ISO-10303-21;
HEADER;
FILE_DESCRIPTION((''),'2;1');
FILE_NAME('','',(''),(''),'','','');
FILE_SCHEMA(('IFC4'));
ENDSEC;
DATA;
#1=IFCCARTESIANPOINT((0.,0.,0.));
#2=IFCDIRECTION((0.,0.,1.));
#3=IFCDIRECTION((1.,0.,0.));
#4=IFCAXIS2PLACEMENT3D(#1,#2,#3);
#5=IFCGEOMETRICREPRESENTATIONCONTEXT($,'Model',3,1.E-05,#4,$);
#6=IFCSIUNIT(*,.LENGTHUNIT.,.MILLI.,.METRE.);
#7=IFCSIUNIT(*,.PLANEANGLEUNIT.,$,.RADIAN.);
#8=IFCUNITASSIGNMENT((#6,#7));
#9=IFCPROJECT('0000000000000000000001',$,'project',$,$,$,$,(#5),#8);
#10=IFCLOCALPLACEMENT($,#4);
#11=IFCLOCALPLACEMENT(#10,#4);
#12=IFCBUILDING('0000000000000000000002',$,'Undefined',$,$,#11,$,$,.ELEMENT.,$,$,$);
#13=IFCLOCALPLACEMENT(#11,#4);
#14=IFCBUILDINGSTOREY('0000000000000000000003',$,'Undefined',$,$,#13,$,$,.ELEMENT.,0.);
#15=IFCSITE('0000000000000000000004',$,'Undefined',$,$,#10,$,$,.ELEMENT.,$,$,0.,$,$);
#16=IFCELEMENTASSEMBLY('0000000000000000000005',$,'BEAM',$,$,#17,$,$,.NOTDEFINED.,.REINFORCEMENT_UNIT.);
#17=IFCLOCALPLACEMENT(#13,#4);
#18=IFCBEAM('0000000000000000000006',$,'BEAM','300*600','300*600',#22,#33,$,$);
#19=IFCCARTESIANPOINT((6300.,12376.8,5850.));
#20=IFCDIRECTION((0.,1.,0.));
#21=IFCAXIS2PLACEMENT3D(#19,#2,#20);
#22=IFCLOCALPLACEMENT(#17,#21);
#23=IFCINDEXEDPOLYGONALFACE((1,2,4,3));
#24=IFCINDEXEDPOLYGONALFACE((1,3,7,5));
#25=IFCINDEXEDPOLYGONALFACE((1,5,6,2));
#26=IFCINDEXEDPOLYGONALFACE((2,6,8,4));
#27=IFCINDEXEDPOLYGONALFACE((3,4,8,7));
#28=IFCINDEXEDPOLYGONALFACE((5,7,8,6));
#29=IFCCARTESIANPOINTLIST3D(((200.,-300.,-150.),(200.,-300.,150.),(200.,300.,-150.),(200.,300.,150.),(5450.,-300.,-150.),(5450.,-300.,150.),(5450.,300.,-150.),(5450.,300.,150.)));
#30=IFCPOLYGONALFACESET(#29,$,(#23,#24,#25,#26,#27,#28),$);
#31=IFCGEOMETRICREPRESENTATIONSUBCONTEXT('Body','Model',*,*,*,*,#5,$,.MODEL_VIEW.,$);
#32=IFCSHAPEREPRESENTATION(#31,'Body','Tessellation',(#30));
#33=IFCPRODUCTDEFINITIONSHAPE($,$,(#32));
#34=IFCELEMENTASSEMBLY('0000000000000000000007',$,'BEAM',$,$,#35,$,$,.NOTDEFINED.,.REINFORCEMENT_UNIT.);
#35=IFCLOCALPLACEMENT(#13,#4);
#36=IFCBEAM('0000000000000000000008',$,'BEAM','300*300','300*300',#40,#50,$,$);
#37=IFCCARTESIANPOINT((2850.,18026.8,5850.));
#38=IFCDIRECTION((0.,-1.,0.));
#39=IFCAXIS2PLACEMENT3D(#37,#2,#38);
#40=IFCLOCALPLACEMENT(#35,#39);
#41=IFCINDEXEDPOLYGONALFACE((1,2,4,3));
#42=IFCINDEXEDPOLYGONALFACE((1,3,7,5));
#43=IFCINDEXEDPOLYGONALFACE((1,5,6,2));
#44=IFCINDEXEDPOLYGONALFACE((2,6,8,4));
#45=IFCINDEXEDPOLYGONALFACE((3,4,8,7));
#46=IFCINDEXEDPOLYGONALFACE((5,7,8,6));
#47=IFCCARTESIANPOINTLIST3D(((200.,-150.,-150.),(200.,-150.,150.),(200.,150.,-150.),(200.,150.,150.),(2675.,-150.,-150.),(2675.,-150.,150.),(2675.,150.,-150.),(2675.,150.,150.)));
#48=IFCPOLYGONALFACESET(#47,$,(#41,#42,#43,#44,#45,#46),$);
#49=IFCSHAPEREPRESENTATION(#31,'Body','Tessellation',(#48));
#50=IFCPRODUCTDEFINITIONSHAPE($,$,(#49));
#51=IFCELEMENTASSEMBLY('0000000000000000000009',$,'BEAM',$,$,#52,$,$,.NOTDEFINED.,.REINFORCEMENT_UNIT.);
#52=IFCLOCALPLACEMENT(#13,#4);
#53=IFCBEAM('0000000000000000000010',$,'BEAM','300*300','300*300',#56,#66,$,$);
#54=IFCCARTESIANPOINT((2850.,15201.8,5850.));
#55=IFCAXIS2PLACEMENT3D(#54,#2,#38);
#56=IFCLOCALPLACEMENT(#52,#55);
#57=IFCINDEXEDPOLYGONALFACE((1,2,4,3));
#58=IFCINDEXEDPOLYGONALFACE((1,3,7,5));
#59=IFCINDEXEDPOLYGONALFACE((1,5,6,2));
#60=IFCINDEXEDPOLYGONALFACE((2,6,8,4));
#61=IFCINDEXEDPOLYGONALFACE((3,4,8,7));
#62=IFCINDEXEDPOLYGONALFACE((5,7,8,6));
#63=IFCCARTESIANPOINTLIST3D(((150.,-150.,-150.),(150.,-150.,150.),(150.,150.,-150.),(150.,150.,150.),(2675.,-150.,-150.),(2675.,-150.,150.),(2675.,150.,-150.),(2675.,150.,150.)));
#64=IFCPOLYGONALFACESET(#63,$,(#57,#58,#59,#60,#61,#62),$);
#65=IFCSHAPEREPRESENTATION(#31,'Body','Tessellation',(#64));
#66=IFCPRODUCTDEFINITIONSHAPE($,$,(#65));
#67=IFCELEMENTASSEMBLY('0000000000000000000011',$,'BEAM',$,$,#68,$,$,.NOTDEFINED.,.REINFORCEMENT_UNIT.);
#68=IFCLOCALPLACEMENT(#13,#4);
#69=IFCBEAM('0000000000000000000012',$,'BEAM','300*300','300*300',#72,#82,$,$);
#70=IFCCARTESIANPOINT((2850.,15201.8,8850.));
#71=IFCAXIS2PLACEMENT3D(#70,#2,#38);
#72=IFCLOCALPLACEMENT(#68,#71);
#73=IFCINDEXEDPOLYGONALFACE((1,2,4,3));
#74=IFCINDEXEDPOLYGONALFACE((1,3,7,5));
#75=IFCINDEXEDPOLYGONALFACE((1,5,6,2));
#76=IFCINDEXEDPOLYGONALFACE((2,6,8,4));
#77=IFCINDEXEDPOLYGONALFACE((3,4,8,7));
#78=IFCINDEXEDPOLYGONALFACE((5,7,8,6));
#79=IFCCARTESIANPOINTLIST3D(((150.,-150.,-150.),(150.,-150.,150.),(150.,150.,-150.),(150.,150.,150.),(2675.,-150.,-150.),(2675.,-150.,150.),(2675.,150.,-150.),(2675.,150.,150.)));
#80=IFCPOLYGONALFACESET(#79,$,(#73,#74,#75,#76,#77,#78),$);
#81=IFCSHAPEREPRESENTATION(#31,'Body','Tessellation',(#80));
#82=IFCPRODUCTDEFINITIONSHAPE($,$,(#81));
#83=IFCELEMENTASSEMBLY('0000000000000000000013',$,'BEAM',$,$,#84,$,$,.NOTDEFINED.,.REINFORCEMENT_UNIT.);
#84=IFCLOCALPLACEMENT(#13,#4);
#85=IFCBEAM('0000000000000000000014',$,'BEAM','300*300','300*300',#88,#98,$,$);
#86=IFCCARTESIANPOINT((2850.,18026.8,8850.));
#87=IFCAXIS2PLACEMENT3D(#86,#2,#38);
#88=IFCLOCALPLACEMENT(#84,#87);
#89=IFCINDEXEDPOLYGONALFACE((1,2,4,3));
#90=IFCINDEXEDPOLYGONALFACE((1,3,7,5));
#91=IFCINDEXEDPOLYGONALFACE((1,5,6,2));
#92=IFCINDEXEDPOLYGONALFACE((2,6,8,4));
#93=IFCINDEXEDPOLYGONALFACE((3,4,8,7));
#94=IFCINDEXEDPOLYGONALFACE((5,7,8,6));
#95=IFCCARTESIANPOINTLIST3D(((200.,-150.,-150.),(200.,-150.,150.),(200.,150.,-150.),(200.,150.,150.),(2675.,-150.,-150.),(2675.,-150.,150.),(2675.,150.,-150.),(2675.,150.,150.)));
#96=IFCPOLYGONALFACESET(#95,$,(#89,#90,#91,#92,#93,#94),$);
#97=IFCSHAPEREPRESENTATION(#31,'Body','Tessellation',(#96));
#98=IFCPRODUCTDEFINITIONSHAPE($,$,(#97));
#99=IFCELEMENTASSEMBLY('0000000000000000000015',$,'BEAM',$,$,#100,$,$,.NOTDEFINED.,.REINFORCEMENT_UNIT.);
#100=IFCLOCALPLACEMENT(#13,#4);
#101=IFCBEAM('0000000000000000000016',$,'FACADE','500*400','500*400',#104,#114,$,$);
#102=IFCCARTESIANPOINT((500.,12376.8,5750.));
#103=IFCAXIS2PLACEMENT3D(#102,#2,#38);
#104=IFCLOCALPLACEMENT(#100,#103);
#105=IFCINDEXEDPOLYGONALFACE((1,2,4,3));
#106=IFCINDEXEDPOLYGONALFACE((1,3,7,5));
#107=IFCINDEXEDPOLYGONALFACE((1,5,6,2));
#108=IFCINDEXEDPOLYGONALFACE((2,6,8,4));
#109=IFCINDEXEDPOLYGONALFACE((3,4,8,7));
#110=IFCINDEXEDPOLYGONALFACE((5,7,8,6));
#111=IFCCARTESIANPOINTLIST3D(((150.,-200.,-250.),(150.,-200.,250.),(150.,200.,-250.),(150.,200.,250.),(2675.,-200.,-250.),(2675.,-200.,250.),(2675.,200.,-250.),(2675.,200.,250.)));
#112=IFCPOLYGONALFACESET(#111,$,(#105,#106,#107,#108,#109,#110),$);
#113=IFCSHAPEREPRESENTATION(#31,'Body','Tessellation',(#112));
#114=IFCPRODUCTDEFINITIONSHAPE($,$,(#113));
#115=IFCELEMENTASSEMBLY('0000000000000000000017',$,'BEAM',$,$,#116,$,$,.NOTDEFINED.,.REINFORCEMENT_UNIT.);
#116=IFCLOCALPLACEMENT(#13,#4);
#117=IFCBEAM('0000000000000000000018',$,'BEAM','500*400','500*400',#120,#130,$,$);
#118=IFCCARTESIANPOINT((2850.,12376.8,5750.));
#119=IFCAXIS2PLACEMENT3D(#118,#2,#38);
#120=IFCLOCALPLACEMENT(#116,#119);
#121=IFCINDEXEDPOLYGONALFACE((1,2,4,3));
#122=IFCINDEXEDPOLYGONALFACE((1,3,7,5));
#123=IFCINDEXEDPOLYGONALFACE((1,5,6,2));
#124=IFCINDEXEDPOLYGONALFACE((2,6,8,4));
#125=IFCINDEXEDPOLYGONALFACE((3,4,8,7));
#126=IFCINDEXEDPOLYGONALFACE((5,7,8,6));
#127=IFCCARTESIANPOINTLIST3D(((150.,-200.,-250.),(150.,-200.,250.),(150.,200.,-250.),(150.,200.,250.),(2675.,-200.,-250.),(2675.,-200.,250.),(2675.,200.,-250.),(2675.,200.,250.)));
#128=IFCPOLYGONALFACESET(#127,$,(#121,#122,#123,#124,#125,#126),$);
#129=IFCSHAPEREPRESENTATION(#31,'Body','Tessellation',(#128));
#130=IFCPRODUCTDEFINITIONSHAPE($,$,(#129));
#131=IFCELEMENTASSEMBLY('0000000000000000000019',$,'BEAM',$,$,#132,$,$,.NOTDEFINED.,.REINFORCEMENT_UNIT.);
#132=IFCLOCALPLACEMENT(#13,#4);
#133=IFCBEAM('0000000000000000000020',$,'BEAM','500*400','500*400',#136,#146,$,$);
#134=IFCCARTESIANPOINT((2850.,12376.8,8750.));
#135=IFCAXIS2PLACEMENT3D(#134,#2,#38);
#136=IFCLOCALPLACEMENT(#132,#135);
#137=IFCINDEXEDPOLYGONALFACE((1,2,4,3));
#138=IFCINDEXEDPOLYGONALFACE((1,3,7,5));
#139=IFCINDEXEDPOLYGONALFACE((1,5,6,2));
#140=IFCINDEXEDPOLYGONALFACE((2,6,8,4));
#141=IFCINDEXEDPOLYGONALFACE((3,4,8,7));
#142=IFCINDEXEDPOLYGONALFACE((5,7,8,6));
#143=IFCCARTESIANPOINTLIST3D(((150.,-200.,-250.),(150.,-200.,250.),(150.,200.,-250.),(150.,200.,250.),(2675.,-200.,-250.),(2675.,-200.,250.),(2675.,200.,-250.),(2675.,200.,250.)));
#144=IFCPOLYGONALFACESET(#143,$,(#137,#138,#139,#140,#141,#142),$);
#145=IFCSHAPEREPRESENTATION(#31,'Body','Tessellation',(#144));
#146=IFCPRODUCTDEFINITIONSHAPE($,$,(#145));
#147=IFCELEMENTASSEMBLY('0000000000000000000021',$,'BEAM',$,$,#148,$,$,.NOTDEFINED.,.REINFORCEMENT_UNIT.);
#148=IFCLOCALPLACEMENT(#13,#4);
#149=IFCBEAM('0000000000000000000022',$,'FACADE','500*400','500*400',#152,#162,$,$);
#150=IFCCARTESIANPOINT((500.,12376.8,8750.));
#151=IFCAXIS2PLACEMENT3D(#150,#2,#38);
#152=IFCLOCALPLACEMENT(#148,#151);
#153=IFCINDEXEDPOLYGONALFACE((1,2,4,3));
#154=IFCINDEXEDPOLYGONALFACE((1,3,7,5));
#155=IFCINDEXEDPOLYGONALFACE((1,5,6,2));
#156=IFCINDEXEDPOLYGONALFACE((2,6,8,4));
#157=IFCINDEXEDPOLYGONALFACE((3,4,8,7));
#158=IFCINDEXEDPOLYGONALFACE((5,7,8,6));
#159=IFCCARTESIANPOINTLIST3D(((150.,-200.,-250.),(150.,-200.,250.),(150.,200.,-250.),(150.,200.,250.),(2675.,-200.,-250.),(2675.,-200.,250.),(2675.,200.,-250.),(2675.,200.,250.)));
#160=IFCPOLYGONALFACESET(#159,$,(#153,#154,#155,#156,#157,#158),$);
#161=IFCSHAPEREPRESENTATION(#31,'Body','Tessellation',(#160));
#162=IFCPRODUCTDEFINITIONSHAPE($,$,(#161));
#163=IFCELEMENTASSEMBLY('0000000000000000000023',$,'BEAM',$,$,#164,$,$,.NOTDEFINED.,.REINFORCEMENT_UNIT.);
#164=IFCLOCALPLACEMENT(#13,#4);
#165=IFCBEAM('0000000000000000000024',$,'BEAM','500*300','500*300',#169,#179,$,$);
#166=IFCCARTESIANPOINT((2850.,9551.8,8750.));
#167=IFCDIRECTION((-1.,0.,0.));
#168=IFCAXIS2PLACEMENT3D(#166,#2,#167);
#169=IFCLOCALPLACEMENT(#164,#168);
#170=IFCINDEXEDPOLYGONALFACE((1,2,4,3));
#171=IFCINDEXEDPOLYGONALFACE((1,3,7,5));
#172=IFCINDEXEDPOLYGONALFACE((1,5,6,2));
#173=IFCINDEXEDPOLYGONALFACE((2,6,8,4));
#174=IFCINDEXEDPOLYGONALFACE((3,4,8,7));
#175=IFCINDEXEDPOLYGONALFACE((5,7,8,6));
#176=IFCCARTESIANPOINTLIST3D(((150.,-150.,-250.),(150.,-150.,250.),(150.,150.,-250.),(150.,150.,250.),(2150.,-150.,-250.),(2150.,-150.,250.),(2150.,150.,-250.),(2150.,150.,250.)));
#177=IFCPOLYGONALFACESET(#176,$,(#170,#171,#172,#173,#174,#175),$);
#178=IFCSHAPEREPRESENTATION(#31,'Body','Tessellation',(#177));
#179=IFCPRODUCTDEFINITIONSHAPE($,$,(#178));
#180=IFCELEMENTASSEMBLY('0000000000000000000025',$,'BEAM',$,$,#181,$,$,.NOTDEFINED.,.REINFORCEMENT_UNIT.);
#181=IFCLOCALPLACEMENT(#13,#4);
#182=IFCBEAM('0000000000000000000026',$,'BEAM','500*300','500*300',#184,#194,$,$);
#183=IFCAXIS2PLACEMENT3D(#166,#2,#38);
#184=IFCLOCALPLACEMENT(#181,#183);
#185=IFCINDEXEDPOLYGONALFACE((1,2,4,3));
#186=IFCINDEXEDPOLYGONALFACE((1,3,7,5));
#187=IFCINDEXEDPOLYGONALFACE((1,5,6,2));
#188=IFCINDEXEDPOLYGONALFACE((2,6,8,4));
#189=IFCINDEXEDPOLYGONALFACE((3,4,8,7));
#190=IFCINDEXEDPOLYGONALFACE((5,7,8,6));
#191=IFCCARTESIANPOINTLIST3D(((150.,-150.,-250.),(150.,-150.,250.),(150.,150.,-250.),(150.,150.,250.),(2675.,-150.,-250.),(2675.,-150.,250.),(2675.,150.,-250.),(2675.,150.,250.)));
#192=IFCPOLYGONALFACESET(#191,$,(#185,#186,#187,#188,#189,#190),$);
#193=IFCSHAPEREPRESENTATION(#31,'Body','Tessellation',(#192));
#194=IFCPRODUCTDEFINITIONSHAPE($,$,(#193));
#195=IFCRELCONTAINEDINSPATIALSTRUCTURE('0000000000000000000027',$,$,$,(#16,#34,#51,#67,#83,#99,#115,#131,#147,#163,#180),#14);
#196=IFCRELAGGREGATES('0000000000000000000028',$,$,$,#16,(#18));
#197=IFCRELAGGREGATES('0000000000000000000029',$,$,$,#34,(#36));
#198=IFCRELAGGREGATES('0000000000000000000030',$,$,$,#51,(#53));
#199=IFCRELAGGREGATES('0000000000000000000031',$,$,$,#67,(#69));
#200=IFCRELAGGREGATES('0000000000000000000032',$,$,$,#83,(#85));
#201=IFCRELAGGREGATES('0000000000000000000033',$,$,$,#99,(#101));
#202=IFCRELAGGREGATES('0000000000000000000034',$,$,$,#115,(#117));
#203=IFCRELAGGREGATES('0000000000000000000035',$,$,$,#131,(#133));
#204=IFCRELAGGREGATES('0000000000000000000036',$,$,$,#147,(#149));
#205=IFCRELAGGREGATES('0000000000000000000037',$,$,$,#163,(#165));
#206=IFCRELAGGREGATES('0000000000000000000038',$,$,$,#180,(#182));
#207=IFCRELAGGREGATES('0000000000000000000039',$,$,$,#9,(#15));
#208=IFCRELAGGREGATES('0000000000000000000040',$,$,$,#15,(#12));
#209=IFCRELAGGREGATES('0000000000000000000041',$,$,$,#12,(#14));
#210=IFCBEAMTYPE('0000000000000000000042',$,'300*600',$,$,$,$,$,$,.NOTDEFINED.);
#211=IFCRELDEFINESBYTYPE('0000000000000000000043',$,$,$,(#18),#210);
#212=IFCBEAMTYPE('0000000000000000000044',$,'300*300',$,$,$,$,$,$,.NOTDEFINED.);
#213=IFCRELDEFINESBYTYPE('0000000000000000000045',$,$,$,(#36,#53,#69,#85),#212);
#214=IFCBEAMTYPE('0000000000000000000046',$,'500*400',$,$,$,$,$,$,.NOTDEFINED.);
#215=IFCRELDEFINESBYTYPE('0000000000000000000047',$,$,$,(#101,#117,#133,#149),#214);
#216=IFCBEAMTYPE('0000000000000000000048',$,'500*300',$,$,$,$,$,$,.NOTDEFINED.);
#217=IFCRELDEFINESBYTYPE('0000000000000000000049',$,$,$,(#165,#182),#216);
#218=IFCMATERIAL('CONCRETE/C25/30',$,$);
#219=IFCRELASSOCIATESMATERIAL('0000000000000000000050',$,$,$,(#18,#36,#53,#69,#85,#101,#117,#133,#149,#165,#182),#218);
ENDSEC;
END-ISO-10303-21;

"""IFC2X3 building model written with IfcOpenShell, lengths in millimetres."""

from ifc_helpers import new_model, si_unit, frame, origin_with_axes, origin_2d_with_axis, place, context, subcontext, project, spatial, rectangle, extrude, material, type_object, element, aggregate, save


model = new_model("IFC2X3")

# Units and contexts
model_context = context("Model", 3, precision=1e-05, world=origin_with_axes())
body_context = subcontext(model_context, "Body", "Model", "MODEL_VIEW")
ifc_project = project(units=[si_unit("LENGTHUNIT", "METRE", prefix="MILLI"), si_unit("PLANEANGLEUNIT", "RADIAN")], contexts=[model_context])

# Site, building, storey
site_placement = place(None, origin_with_axes())
site = spatial("IfcSite", under=ifc_project, at=site_placement, Name="Undefined", CompositionType="ELEMENT", RefElevation=0.0)
building_placement = place(site_placement, origin_with_axes())
building = spatial("IfcBuilding", under=site, at=building_placement, Name="Undefined", CompositionType="ELEMENT")
storey_placement = place(building_placement, origin_with_axes())
storey = spatial("IfcBuildingStorey", under=building, at=storey_placement, Name="Undefined", CompositionType="ELEMENT", Elevation=0.0)

# Shared definitions
ifc_material = material(Name="CONCRETE/C25/30")

# Element assemblies, beams
assembly_1_placement = place(storey_placement, origin_with_axes())
assembly_1 = element("IfcElementAssembly", 1, at=assembly_1_placement, inside=storey, Name="BEAM", AssemblyPlace="NOTDEFINED", PredefinedType="REINFORCEMENT_UNIT")
beam_type_1 = type_object("IfcBeamType", Name="300*600", PredefinedType="NOTDEFINED")
beam_1_placement = place(assembly_1_placement, frame((6300.0, 12376.8, 5850.0), z_axis=(0.0, 0.0, 1.0), x_axis=(0.0, 1.0, 0.0)))
beam_1 = element("IfcBeam", 2, at=beam_1_placement, type_object=beam_type_1, material=ifc_material, Name="BEAM", Description="300*600", ObjectType="300*600", context=body_context, shape_type="SweptSolid", body=[
    extrude(rectangle(XDim=600.0, YDim=300.0, at=origin_2d_with_axis()), frame((5450.0, 0.0, 0.0), z_axis=(-1.0, 0.0, 0.0), x_axis=(0.0, -1.0, 0.0)), (0.0, 0.0, 1.0), 5250.0),
])
aggregate(assembly_1, [beam_1])
assembly_2_placement = place(storey_placement, origin_with_axes())
assembly_2 = element("IfcElementAssembly", 3, at=assembly_2_placement, inside=storey, Name="BEAM", AssemblyPlace="NOTDEFINED", PredefinedType="REINFORCEMENT_UNIT")
beam_type_2 = type_object("IfcBeamType", Name="300*300", PredefinedType="NOTDEFINED")
beam_2_placement = place(assembly_2_placement, frame((2850.0, 18026.8, 5850.0), z_axis=(0.0, 0.0, 1.0), x_axis=(0.0, -1.0, 0.0)))
beam_2 = element("IfcBeam", 4, at=beam_2_placement, type_object=beam_type_2, material=ifc_material, Name="BEAM", Description="300*300", ObjectType="300*300", context=body_context, shape_type="SweptSolid", body=[
    extrude(rectangle(XDim=300.0, YDim=300.0, at=origin_2d_with_axis()), frame((2675.0, 0.0, 0.0), z_axis=(-1.0, 0.0, 0.0), x_axis=(0.0, -1.0, 0.0)), (0.0, 0.0, 1.0), 2475.0),
])
aggregate(assembly_2, [beam_2])
assembly_3_placement = place(storey_placement, origin_with_axes())
assembly_3 = element("IfcElementAssembly", 5, at=assembly_3_placement, inside=storey, Name="BEAM", AssemblyPlace="NOTDEFINED", PredefinedType="REINFORCEMENT_UNIT")
beam_3_placement = place(assembly_3_placement, frame((2850.0, 15201.8, 5850.0), z_axis=(0.0, 0.0, 1.0), x_axis=(0.0, -1.0, 0.0)))
beam_3 = element("IfcBeam", 6, at=beam_3_placement, type_object=beam_type_2, material=ifc_material, Name="BEAM", Description="300*300", ObjectType="300*300", context=body_context, shape_type="SweptSolid", body=[
    extrude(rectangle(XDim=300.0, YDim=300.0, at=origin_2d_with_axis()), frame((2675.0, 0.0, 0.0), z_axis=(-1.0, 0.0, 0.0), x_axis=(0.0, -1.0, 0.0)), (0.0, 0.0, 1.0), 2525.0),
])
aggregate(assembly_3, [beam_3])
assembly_4_placement = place(storey_placement, origin_with_axes())
assembly_4 = element("IfcElementAssembly", 7, at=assembly_4_placement, inside=storey, Name="BEAM", AssemblyPlace="NOTDEFINED", PredefinedType="REINFORCEMENT_UNIT")
beam_4_placement = place(assembly_4_placement, frame((2850.0, 15201.8, 8850.0), z_axis=(0.0, 0.0, 1.0), x_axis=(0.0, -1.0, 0.0)))
beam_4 = element("IfcBeam", 8, at=beam_4_placement, type_object=beam_type_2, material=ifc_material, Name="BEAM", Description="300*300", ObjectType="300*300", context=body_context, shape_type="SweptSolid", body=[
    extrude(rectangle(XDim=300.0, YDim=300.0, at=origin_2d_with_axis()), frame((2675.0, 0.0, 0.0), z_axis=(-1.0, 0.0, 0.0), x_axis=(0.0, -1.0, 0.0)), (0.0, 0.0, 1.0), 2525.0),
])
aggregate(assembly_4, [beam_4])
assembly_5_placement = place(storey_placement, origin_with_axes())
assembly_5 = element("IfcElementAssembly", 9, at=assembly_5_placement, inside=storey, Name="BEAM", AssemblyPlace="NOTDEFINED", PredefinedType="REINFORCEMENT_UNIT")
beam_5_placement = place(assembly_5_placement, frame((2850.0, 18026.8, 8850.0), z_axis=(0.0, 0.0, 1.0), x_axis=(0.0, -1.0, 0.0)))
beam_5 = element("IfcBeam", 10, at=beam_5_placement, type_object=beam_type_2, material=ifc_material, Name="BEAM", Description="300*300", ObjectType="300*300", context=body_context, shape_type="SweptSolid", body=[
    extrude(rectangle(XDim=300.0, YDim=300.0, at=origin_2d_with_axis()), frame((2675.0, 0.0, 0.0), z_axis=(-1.0, 0.0, 0.0), x_axis=(0.0, -1.0, 0.0)), (0.0, 0.0, 1.0), 2475.0),
])
aggregate(assembly_5, [beam_5])
assembly_6_placement = place(storey_placement, origin_with_axes())
assembly_6 = element("IfcElementAssembly", 11, at=assembly_6_placement, inside=storey, Name="BEAM", AssemblyPlace="NOTDEFINED", PredefinedType="REINFORCEMENT_UNIT")
beam_type_3 = type_object("IfcBeamType", Name="500*400", PredefinedType="NOTDEFINED")
beam_6_placement = place(assembly_6_placement, frame((500.0, 12376.8, 5750.0), z_axis=(0.0, 0.0, 1.0), x_axis=(0.0, -1.0, 0.0)))
beam_6 = element("IfcBeam", 12, at=beam_6_placement, type_object=beam_type_3, material=ifc_material, Name="FACADE", Description="500*400", ObjectType="500*400", context=body_context, shape_type="SweptSolid", body=[
    extrude(rectangle(XDim=400.0, YDim=500.0, at=origin_2d_with_axis()), frame((2675.0, 0.0, 0.0), z_axis=(-1.0, 0.0, 0.0), x_axis=(0.0, -1.0, 0.0)), (0.0, 0.0, 1.0), 2525.0),
])
aggregate(assembly_6, [beam_6])
assembly_7_placement = place(storey_placement, origin_with_axes())
assembly_7 = element("IfcElementAssembly", 13, at=assembly_7_placement, inside=storey, Name="BEAM", AssemblyPlace="NOTDEFINED", PredefinedType="REINFORCEMENT_UNIT")
beam_7_placement = place(assembly_7_placement, frame((2850.0, 12376.8, 5750.0), z_axis=(0.0, 0.0, 1.0), x_axis=(0.0, -1.0, 0.0)))
beam_7 = element("IfcBeam", 14, at=beam_7_placement, type_object=beam_type_3, material=ifc_material, Name="BEAM", Description="500*400", ObjectType="500*400", context=body_context, shape_type="SweptSolid", body=[
    extrude(rectangle(XDim=400.0, YDim=500.0, at=origin_2d_with_axis()), frame((2675.0, 0.0, 0.0), z_axis=(-1.0, 0.0, 0.0), x_axis=(0.0, -1.0, 0.0)), (0.0, 0.0, 1.0), 2525.0),
])
aggregate(assembly_7, [beam_7])
assembly_8_placement = place(storey_placement, origin_with_axes())
assembly_8 = element("IfcElementAssembly", 15, at=assembly_8_placement, inside=storey, Name="BEAM", AssemblyPlace="NOTDEFINED", PredefinedType="REINFORCEMENT_UNIT")
beam_8_placement = place(assembly_8_placement, frame((2850.0, 12376.8, 8750.0), z_axis=(0.0, 0.0, 1.0), x_axis=(0.0, -1.0, 0.0)))
beam_8 = element("IfcBeam", 16, at=beam_8_placement, type_object=beam_type_3, material=ifc_material, Name="BEAM", Description="500*400", ObjectType="500*400", context=body_context, shape_type="SweptSolid", body=[
    extrude(rectangle(XDim=400.0, YDim=500.0, at=origin_2d_with_axis()), frame((2675.0, 0.0, 0.0), z_axis=(-1.0, 0.0, 0.0), x_axis=(0.0, -1.0, 0.0)), (0.0, 0.0, 1.0), 2525.0),
])
aggregate(assembly_8, [beam_8])
assembly_9_placement = place(storey_placement, origin_with_axes())
assembly_9 = element("IfcElementAssembly", 17, at=assembly_9_placement, inside=storey, Name="BEAM", AssemblyPlace="NOTDEFINED", PredefinedType="REINFORCEMENT_UNIT")
beam_9_placement = place(assembly_9_placement, frame((500.0, 12376.8, 8750.0), z_axis=(0.0, 0.0, 1.0), x_axis=(0.0, -1.0, 0.0)))
beam_9 = element("IfcBeam", 18, at=beam_9_placement, type_object=beam_type_3, material=ifc_material, Name="FACADE", Description="500*400", ObjectType="500*400", context=body_context, shape_type="SweptSolid", body=[
    extrude(rectangle(XDim=400.0, YDim=500.0, at=origin_2d_with_axis()), frame((2675.0, 0.0, 0.0), z_axis=(-1.0, 0.0, 0.0), x_axis=(0.0, -1.0, 0.0)), (0.0, 0.0, 1.0), 2525.0),
])
aggregate(assembly_9, [beam_9])
assembly_10_placement = place(storey_placement, origin_with_axes())
assembly_10 = element("IfcElementAssembly", 19, at=assembly_10_placement, inside=storey, Name="BEAM", AssemblyPlace="NOTDEFINED", PredefinedType="REINFORCEMENT_UNIT")
beam_type_4 = type_object("IfcBeamType", Name="500*300", PredefinedType="NOTDEFINED")
beam_10_placement = place(assembly_10_placement, frame((2850.0, 9551.8, 8750.0), z_axis=(0.0, 0.0, 1.0), x_axis=(-1.0, 0.0, 0.0)))
beam_10 = element("IfcBeam", 20, at=beam_10_placement, type_object=beam_type_4, material=ifc_material, Name="BEAM", Description="500*300", ObjectType="500*300", context=body_context, shape_type="SweptSolid", body=[
    extrude(rectangle(XDim=300.0, YDim=500.0, at=origin_2d_with_axis()), frame((2150.0, 0.0, 0.0), z_axis=(-1.0, 0.0, 0.0), x_axis=(0.0, -1.0, 0.0)), (0.0, 0.0, 1.0), 2000.0),
])
aggregate(assembly_10, [beam_10])
assembly_11_placement = place(storey_placement, origin_with_axes())
assembly_11 = element("IfcElementAssembly", 21, at=assembly_11_placement, inside=storey, Name="BEAM", AssemblyPlace="NOTDEFINED", PredefinedType="REINFORCEMENT_UNIT")
beam_11_placement = place(assembly_11_placement, frame((2850.0, 9551.8, 8750.0), z_axis=(0.0, 0.0, 1.0), x_axis=(0.0, -1.0, 0.0)))
beam_11 = element("IfcBeam", 22, at=beam_11_placement, type_object=beam_type_4, material=ifc_material, Name="BEAM", Description="500*300", ObjectType="500*300", context=body_context, shape_type="SweptSolid", body=[
    extrude(rectangle(XDim=300.0, YDim=500.0, at=origin_2d_with_axis()), frame((2675.0, 0.0, 0.0), z_axis=(-1.0, 0.0, 0.0), x_axis=(0.0, -1.0, 0.0)), (0.0, 0.0, 1.0), 2525.0),
])
aggregate(assembly_11, [beam_11])

save(model, "model.ifc")
